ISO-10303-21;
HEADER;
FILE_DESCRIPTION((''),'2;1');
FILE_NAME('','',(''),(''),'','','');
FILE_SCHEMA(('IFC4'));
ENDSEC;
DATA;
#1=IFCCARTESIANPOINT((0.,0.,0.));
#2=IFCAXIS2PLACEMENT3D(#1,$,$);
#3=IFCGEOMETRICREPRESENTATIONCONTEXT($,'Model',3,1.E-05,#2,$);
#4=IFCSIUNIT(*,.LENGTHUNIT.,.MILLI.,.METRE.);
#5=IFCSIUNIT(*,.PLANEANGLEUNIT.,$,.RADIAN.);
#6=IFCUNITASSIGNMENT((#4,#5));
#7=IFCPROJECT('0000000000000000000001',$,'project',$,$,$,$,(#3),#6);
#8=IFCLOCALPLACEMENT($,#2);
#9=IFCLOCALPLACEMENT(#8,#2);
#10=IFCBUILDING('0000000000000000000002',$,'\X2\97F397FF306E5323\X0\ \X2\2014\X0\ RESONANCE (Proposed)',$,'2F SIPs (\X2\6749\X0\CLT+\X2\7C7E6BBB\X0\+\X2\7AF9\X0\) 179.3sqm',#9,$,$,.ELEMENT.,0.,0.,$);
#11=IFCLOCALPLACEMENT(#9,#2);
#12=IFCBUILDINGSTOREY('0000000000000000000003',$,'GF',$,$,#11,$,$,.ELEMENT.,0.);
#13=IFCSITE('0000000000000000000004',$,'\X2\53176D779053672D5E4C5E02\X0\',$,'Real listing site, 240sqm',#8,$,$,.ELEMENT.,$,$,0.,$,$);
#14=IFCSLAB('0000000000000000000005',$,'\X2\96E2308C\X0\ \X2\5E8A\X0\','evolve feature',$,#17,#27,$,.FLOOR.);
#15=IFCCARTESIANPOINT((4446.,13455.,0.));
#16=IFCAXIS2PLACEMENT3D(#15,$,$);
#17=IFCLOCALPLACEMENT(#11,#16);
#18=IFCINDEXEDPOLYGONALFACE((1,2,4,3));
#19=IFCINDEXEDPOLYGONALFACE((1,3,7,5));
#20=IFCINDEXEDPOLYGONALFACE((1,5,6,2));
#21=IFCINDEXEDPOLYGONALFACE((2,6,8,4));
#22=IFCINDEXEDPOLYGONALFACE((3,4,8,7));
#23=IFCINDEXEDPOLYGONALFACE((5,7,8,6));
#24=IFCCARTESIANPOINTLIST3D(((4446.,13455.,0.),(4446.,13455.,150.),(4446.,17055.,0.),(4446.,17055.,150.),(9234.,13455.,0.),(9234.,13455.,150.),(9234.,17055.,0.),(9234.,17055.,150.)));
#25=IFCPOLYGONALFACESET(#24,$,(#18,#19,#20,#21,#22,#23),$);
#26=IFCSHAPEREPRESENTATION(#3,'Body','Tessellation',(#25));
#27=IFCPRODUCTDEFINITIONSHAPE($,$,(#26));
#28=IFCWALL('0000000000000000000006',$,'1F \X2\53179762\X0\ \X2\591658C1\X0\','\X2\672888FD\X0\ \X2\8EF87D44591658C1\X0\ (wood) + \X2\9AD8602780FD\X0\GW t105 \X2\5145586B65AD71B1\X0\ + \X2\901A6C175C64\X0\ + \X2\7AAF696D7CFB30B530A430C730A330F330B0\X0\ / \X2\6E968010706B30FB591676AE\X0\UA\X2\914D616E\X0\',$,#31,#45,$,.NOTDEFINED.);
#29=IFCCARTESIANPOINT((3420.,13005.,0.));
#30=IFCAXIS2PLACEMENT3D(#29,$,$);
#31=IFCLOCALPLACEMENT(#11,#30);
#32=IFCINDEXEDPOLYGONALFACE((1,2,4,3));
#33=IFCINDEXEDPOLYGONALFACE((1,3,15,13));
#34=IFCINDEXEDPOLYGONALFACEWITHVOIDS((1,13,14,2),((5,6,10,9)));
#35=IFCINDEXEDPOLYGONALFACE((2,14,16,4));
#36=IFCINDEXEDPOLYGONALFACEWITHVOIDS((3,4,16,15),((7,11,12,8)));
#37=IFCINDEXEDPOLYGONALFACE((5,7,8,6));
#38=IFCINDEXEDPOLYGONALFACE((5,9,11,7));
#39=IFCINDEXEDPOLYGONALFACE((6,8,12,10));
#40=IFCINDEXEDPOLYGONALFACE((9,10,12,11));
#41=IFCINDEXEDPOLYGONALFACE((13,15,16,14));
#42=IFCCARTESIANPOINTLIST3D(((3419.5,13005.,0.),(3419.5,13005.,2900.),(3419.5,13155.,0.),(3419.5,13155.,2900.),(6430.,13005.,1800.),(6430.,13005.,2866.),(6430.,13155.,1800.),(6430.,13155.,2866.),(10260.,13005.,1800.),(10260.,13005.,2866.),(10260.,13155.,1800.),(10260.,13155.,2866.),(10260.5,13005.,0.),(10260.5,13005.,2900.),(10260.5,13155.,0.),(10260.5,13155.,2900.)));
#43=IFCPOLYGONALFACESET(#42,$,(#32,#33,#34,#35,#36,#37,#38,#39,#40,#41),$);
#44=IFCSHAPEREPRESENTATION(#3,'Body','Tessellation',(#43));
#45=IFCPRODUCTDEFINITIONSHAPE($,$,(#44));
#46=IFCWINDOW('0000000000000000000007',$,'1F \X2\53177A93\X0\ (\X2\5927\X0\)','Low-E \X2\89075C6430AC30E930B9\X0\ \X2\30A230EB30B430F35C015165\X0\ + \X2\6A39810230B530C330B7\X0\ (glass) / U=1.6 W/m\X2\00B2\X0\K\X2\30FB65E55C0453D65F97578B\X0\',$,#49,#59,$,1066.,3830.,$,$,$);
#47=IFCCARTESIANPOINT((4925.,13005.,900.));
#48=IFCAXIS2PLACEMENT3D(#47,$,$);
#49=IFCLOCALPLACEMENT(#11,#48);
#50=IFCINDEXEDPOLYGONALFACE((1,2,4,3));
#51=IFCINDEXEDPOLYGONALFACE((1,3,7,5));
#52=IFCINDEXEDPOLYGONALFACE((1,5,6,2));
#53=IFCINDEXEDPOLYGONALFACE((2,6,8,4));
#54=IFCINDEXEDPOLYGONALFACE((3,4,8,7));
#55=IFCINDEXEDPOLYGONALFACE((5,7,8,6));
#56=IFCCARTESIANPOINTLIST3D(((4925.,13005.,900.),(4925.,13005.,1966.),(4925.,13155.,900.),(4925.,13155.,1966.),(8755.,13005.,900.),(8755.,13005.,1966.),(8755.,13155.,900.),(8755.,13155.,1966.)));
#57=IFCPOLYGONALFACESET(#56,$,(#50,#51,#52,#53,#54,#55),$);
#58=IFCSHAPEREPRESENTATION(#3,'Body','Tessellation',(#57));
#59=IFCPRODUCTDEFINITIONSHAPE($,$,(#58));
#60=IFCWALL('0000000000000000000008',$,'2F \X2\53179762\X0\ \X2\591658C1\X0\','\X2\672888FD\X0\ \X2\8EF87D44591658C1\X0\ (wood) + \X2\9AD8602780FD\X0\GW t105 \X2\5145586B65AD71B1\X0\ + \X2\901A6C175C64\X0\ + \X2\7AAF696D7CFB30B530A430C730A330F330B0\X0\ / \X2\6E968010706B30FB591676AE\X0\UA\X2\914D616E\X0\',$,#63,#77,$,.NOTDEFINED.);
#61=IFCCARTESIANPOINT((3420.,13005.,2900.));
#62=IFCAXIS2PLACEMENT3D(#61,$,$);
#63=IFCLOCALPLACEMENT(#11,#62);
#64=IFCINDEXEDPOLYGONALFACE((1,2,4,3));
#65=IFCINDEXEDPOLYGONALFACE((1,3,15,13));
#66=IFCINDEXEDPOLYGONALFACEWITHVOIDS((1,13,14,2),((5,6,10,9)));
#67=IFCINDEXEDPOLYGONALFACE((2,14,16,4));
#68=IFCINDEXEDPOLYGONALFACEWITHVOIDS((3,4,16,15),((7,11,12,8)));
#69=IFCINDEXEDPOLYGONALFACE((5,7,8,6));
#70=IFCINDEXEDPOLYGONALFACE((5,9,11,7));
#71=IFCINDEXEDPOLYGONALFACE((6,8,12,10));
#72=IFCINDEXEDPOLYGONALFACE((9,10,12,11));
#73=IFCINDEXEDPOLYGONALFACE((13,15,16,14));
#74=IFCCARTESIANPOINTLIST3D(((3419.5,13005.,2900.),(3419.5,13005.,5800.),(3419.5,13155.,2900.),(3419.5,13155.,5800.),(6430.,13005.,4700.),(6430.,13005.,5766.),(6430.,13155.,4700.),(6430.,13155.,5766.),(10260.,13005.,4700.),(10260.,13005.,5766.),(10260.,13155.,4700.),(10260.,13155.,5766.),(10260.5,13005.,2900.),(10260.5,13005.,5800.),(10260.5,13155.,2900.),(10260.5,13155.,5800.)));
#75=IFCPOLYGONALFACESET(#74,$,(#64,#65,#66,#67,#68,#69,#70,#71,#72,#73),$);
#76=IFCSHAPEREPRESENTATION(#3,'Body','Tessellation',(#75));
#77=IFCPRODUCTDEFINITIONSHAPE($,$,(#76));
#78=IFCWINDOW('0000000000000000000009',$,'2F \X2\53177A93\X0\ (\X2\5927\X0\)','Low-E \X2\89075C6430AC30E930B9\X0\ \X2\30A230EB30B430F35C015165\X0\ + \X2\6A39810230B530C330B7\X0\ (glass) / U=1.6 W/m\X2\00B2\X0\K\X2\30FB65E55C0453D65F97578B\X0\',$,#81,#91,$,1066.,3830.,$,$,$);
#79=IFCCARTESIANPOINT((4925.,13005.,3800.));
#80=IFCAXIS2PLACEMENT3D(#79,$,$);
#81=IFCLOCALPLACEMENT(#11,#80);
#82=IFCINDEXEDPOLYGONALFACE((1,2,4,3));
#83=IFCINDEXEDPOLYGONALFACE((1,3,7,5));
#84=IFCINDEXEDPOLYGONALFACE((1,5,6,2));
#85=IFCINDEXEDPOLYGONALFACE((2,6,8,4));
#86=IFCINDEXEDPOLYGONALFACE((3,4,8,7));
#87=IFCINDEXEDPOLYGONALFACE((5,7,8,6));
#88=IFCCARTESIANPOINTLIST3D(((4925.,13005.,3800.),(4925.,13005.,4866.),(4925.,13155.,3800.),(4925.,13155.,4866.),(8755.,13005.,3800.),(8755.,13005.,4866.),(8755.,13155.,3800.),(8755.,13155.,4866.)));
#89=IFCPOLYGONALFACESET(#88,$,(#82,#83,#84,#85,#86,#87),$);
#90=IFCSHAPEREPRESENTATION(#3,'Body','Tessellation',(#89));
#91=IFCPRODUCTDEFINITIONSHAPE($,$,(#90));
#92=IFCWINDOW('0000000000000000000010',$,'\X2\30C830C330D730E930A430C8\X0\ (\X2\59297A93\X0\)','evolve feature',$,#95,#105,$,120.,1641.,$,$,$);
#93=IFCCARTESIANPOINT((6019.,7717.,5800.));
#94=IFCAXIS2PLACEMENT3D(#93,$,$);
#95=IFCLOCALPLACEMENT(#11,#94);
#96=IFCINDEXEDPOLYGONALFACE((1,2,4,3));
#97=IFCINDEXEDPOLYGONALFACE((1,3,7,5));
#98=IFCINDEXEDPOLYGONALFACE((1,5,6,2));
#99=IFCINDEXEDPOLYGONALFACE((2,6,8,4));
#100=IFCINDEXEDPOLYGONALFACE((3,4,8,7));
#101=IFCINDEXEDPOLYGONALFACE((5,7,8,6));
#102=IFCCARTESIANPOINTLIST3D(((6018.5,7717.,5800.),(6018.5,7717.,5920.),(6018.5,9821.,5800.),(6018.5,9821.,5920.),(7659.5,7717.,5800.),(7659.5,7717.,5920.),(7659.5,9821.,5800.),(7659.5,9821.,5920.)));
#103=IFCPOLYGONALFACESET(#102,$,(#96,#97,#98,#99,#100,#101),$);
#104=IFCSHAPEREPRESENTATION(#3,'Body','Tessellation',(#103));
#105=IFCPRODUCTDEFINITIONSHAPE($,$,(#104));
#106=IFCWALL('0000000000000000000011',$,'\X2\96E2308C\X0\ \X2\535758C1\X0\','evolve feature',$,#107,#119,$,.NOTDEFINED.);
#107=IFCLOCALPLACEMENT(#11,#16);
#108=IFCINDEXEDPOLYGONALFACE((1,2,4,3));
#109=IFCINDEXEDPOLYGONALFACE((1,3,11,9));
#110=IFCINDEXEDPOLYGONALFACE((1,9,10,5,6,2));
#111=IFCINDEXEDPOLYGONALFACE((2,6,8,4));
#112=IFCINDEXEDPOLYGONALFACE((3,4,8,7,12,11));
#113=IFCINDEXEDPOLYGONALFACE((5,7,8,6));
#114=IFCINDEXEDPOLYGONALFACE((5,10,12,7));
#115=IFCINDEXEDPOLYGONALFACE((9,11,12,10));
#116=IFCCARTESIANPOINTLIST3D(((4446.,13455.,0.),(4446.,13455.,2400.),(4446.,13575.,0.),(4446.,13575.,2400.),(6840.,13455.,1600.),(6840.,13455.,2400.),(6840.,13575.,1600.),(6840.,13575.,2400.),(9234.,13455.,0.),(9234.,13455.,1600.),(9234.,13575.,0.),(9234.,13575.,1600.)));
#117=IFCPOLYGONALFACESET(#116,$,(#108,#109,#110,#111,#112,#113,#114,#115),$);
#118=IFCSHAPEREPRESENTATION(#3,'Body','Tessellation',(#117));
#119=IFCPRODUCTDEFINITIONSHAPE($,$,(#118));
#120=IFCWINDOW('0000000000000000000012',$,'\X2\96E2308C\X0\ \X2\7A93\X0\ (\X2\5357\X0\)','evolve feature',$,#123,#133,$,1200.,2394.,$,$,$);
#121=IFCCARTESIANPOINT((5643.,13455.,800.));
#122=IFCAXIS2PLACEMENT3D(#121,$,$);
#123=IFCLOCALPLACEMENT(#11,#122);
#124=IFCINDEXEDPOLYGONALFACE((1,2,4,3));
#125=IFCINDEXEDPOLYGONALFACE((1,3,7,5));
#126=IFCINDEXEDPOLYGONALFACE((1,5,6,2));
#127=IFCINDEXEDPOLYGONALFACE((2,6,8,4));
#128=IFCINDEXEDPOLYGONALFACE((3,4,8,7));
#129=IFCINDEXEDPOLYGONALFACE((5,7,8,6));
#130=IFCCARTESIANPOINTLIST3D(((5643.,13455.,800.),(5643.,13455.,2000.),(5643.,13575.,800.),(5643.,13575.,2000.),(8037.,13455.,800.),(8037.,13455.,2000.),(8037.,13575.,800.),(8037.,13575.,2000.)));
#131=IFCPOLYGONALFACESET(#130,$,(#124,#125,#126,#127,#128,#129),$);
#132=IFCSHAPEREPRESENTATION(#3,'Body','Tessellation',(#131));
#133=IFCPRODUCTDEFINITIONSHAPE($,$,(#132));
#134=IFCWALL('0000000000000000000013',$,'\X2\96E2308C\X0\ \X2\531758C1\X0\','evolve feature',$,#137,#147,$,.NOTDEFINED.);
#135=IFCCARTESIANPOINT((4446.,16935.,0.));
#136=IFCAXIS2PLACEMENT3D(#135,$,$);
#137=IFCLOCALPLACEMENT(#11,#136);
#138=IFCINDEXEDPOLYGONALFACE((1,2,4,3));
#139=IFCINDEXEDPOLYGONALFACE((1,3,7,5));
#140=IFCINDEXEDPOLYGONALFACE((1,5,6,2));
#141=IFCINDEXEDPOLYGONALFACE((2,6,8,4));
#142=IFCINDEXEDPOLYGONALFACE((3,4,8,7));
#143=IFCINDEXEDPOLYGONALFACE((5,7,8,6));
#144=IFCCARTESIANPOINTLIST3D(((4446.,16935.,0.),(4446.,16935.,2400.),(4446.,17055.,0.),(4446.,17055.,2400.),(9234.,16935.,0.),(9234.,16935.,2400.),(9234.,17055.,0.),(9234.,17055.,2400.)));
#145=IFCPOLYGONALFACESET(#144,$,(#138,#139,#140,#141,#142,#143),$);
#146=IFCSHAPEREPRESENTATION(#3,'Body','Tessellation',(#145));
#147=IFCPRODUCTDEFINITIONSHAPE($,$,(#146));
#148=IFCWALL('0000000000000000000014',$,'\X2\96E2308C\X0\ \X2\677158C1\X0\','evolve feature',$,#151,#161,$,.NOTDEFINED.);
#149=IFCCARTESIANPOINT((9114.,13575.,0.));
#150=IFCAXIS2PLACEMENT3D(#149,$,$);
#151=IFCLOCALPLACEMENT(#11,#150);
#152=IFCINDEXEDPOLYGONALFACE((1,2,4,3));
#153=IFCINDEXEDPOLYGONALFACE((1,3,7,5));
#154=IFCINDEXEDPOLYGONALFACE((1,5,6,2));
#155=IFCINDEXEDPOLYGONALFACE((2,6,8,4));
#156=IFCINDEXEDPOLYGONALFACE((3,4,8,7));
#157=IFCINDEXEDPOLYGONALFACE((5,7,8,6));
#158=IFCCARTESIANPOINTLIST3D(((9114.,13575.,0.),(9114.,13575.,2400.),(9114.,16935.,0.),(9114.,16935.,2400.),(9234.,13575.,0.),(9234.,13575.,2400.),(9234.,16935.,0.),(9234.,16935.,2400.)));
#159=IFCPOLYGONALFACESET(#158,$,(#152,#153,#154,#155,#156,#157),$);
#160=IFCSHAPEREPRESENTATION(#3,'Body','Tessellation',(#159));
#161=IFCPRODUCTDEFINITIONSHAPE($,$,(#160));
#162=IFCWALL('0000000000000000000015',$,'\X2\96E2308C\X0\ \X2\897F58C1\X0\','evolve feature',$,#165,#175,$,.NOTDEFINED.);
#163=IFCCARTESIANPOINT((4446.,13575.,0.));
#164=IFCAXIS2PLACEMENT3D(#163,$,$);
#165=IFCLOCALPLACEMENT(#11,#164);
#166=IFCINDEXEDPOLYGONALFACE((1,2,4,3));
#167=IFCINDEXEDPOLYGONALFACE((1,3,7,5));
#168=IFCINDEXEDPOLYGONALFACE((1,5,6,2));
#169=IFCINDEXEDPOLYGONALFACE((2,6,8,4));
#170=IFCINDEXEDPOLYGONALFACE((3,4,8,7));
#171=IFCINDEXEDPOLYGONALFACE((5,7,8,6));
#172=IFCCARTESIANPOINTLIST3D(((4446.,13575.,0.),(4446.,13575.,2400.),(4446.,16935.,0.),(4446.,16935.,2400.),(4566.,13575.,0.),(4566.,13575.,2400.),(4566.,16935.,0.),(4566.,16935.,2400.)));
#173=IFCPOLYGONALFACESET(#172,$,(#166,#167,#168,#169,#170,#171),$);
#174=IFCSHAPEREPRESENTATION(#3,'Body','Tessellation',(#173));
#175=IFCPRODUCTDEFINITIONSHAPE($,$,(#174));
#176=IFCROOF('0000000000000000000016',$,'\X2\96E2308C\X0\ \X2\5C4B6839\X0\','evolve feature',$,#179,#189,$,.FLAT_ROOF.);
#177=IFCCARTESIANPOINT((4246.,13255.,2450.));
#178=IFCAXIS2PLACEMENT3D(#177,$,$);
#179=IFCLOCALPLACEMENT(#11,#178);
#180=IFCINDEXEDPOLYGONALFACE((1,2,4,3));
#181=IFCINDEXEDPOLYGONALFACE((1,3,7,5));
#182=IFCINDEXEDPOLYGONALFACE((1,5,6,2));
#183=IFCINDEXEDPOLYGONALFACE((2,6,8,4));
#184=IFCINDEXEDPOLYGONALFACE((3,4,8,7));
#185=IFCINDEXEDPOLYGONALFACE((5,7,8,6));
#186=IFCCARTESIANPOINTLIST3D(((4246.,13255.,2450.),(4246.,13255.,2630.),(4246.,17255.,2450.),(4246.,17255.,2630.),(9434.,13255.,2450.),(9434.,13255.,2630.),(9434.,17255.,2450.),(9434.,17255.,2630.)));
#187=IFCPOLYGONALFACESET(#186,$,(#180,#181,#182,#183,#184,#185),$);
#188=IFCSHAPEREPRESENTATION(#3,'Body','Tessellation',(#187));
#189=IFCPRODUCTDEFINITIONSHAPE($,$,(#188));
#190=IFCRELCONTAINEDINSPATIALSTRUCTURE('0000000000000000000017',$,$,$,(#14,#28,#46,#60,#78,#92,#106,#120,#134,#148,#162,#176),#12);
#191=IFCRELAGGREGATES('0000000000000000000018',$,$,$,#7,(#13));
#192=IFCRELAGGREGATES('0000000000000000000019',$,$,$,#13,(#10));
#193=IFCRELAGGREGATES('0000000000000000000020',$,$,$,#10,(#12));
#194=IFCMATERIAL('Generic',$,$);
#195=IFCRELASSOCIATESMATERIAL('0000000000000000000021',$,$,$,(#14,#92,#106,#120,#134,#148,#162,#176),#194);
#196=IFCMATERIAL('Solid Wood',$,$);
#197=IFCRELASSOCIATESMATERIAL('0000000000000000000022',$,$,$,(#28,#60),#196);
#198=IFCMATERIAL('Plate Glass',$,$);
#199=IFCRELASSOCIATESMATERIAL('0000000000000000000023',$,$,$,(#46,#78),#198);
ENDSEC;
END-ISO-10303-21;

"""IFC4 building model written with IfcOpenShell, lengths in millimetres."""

from ifc_helpers import new_model, si_unit, frame, frame_2d, origin, place, context, project, spatial, rectangle, extrude, material, element, fill, save


model = new_model("IFC4")

# Units and contexts
model_context = context("Model", 3, precision=1e-05, world=origin())
ifc_project = project(units=[si_unit("LENGTHUNIT", "METRE", prefix="MILLI"), si_unit("PLANEANGLEUNIT", "RADIAN")], contexts=[model_context])

# Site, building, storey
site_placement = place(None, origin())
site = spatial("IfcSite", under=ifc_project, at=site_placement, Name="北海道札幌市", ObjectType="Real listing site, 240sqm", CompositionType="ELEMENT", RefElevation=0.0)
building_placement = place(site_placement, origin())
building = spatial("IfcBuilding", under=site, at=building_placement, Name="音響の匣 — RESONANCE (Proposed)", ObjectType="2F SIPs (杉CLT+籾殻+竹) 179.3sqm", CompositionType="ELEMENT", ElevationOfRefHeight=0.0, ElevationOfTerrain=0.0)
storey_placement = place(building_placement, origin())
storey = spatial("IfcBuildingStorey", under=building, at=storey_placement, Name="GF", CompositionType="ELEMENT", Elevation=0.0)

# Slab
ifc_material_1 = material(Name="Generic")
slab_placement = place(storey_placement, frame((4446.0, 13455.0, 0.0)))
element("IfcSlab", 1, at=slab_placement, inside=storey, material=ifc_material_1, Name="離れ 床", Description="evolve feature", PredefinedType="FLOOR", context=model_context, shape_type="SweptSolid", body=[
    extrude(rectangle(XDim=4788.0, YDim=3600.0, at=frame_2d((2394.0, 1800.0))), frame((4446.0, 13455.0, 0.0)), (0.0, 0.0, 1.0), 150.0),
])

# Wall, opening, window
ifc_material_2 = material(Name="Solid Wood")
wall_1_placement = place(storey_placement, frame((3420.0, 13005.0, 0.0)))
wall_1 = element("IfcWall", 2, at=wall_1_placement, inside=storey, material=ifc_material_2, Name="1F 北面 外壁", Description="木製 軸組外壁 (wood) + 高性能GW t105 充填断熱 + 通気層 + 窯業系サイディング / 準耐火・外皮UA配慮", PredefinedType="NOTDEFINED", context=model_context, shape_type="SweptSolid", body=[
    extrude(rectangle(XDim=6841.0, YDim=150.0, at=frame_2d((3420.0, 75.0))), frame((3420.0, 13005.0, 0.0)), (0.0, 0.0, 1.0), 2900.0),
])
opening_1_placement = place(storey_placement, frame((4925.0, 13005.0, 900.0)))
opening_1 = element("IfcOpeningElement", 3, at=opening_1_placement, cuts=wall_1, PredefinedType="NOTDEFINED", context=model_context, shape_type="SweptSolid", body=[
    extrude(rectangle(XDim=3830.0, YDim=150.0, at=frame_2d((1915.0, 75.0))), frame((4925.0, 13005.0, 900.0)), (0.0, 0.0, 1.0), 1066.0),
])
ifc_material_3 = material(Name="Plate Glass")
window_1_placement = place(storey_placement, frame((4925.0, 13005.0, 900.0)))
window_1 = element("IfcWindow", 4, at=window_1_placement, inside=storey, material=ifc_material_3, Name="1F 北窓 (大)", Description="Low-E 複層ガラス アルゴン封入 + 樹脂サッシ (glass) / U=1.6 W/m²K・日射取得型", OverallHeight=1066.0, OverallWidth=3830.0, context=model_context, shape_type="SweptSolid", body=[
    extrude(rectangle(XDim=3830.0, YDim=150.0, at=frame_2d((1915.0, 75.0))), frame((4925.0, 13005.0, 900.0)), (0.0, 0.0, 1.0), 1066.0),
])
fill(opening_1, window_1)

# Wall, opening, window
wall_2_placement = place(storey_placement, frame((3420.0, 13005.0, 2900.0)))
wall_2 = element("IfcWall", 5, at=wall_2_placement, inside=storey, material=ifc_material_2, Name="2F 北面 外壁", Description="木製 軸組外壁 (wood) + 高性能GW t105 充填断熱 + 通気層 + 窯業系サイディング / 準耐火・外皮UA配慮", PredefinedType="NOTDEFINED", context=model_context, shape_type="SweptSolid", body=[
    extrude(rectangle(XDim=6841.0, YDim=150.0, at=frame_2d((3420.0, 75.0))), frame((3420.0, 13005.0, 2900.0)), (0.0, 0.0, 1.0), 2900.0),
])
opening_2_placement = place(storey_placement, frame((4925.0, 13005.0, 3800.0)))
opening_2 = element("IfcOpeningElement", 6, at=opening_2_placement, cuts=wall_2, PredefinedType="NOTDEFINED", context=model_context, shape_type="SweptSolid", body=[
    extrude(rectangle(XDim=3830.0, YDim=150.0, at=frame_2d((1915.0, 75.0))), frame((4925.0, 13005.0, 3800.0)), (0.0, 0.0, 1.0), 1066.0),
])
window_2_placement = place(storey_placement, frame((4925.0, 13005.0, 3800.0)))
window_2 = element("IfcWindow", 7, at=window_2_placement, inside=storey, material=ifc_material_3, Name="2F 北窓 (大)", Description="Low-E 複層ガラス アルゴン封入 + 樹脂サッシ (glass) / U=1.6 W/m²K・日射取得型", OverallHeight=1066.0, OverallWidth=3830.0, context=model_context, shape_type="SweptSolid", body=[
    extrude(rectangle(XDim=3830.0, YDim=150.0, at=frame_2d((1915.0, 75.0))), frame((4925.0, 13005.0, 3800.0)), (0.0, 0.0, 1.0), 1066.0),
])
fill(opening_2, window_2)

# Window
window_3_placement = place(storey_placement, frame((6019.0, 7717.0, 5800.0)))
element("IfcWindow", 8, at=window_3_placement, inside=storey, material=ifc_material_1, Name="トップライト (天窓)", Description="evolve feature", OverallHeight=120.0, OverallWidth=1641.0, context=model_context, shape_type="SweptSolid", body=[
    extrude(rectangle(XDim=1641.0, YDim=2104.0, at=frame_2d((820.0, 1052.0))), frame((6019.0, 7717.0, 5800.0)), (0.0, 0.0, 1.0), 120.0),
])

# Wall, opening, window
wall_3_placement = place(storey_placement, frame((4446.0, 13455.0, 0.0)))
wall_3 = element("IfcWall", 9, at=wall_3_placement, inside=storey, material=ifc_material_1, Name="離れ 南壁", Description="evolve feature", PredefinedType="NOTDEFINED", context=model_context, shape_type="SweptSolid", body=[
    extrude(rectangle(XDim=4788.0, YDim=120.0, at=frame_2d((2394.0, 60.0))), frame((4446.0, 13455.0, 0.0)), (0.0, 0.0, 1.0), 2400.0),
])
opening_3_placement = place(storey_placement, frame((5643.0, 13455.0, 800.0)))
opening_3 = element("IfcOpeningElement", 10, at=opening_3_placement, cuts=wall_3, PredefinedType="NOTDEFINED", context=model_context, shape_type="SweptSolid", body=[
    extrude(rectangle(XDim=2394.0, YDim=120.0, at=frame_2d((1197.0, 60.0))), frame((5643.0, 13455.0, 800.0)), (0.0, 0.0, 1.0), 1200.0),
])
window_4_placement = place(storey_placement, frame((5643.0, 13455.0, 800.0)))
window_4 = element("IfcWindow", 11, at=window_4_placement, inside=storey, material=ifc_material_1, Name="離れ 窓 (南)", Description="evolve feature", OverallHeight=1200.0, OverallWidth=2394.0, context=model_context, shape_type="SweptSolid", body=[
    extrude(rectangle(XDim=2394.0, YDim=120.0, at=frame_2d((1197.0, 60.0))), frame((5643.0, 13455.0, 800.0)), (0.0, 0.0, 1.0), 1200.0),
])
fill(opening_3, window_4)

# Walls
wall_4_placement = place(storey_placement, frame((4446.0, 16935.0, 0.0)))
element("IfcWall", 12, at=wall_4_placement, inside=storey, material=ifc_material_1, Name="離れ 北壁", Description="evolve feature", PredefinedType="NOTDEFINED", context=model_context, shape_type="SweptSolid", body=[
    extrude(rectangle(XDim=4788.0, YDim=120.0, at=frame_2d((2394.0, 60.0))), frame((4446.0, 16935.0, 0.0)), (0.0, 0.0, 1.0), 2400.0),
])
wall_5_placement = place(storey_placement, frame((9114.0, 13575.0, 0.0)))
element("IfcWall", 13, at=wall_5_placement, inside=storey, material=ifc_material_1, Name="離れ 東壁", Description="evolve feature", PredefinedType="NOTDEFINED", context=model_context, shape_type="SweptSolid", body=[
    extrude(rectangle(XDim=120.0, YDim=3360.0, at=frame_2d((60.0, 1680.0))), frame((9114.0, 13575.0, 0.0)), (0.0, 0.0, 1.0), 2400.0),
])
wall_6_placement = place(storey_placement, frame((4446.0, 13575.0, 0.0)))
element("IfcWall", 14, at=wall_6_placement, inside=storey, material=ifc_material_1, Name="離れ 西壁", Description="evolve feature", PredefinedType="NOTDEFINED", context=model_context, shape_type="SweptSolid", body=[
    extrude(rectangle(XDim=120.0, YDim=3360.0, at=frame_2d((60.0, 1680.0))), frame((4446.0, 13575.0, 0.0)), (0.0, 0.0, 1.0), 2400.0),
])

# Roof
roof_1_placement = place(storey_placement, frame((4246.0, 13255.0, 2450.0)))
element("IfcRoof", 15, at=roof_1_placement, inside=storey, material=ifc_material_1, Name="離れ 屋根", Description="evolve feature", PredefinedType="FLAT_ROOF", context=model_context, shape_type="SweptSolid", body=[
    extrude(rectangle(XDim=5188.0, YDim=4000.0, at=frame_2d((2594.0, 2000.0))), frame((4246.0, 13255.0, 2450.0)), (0.0, 0.0, 1.0), 180.0),
])

save(model, "model.ifc")
